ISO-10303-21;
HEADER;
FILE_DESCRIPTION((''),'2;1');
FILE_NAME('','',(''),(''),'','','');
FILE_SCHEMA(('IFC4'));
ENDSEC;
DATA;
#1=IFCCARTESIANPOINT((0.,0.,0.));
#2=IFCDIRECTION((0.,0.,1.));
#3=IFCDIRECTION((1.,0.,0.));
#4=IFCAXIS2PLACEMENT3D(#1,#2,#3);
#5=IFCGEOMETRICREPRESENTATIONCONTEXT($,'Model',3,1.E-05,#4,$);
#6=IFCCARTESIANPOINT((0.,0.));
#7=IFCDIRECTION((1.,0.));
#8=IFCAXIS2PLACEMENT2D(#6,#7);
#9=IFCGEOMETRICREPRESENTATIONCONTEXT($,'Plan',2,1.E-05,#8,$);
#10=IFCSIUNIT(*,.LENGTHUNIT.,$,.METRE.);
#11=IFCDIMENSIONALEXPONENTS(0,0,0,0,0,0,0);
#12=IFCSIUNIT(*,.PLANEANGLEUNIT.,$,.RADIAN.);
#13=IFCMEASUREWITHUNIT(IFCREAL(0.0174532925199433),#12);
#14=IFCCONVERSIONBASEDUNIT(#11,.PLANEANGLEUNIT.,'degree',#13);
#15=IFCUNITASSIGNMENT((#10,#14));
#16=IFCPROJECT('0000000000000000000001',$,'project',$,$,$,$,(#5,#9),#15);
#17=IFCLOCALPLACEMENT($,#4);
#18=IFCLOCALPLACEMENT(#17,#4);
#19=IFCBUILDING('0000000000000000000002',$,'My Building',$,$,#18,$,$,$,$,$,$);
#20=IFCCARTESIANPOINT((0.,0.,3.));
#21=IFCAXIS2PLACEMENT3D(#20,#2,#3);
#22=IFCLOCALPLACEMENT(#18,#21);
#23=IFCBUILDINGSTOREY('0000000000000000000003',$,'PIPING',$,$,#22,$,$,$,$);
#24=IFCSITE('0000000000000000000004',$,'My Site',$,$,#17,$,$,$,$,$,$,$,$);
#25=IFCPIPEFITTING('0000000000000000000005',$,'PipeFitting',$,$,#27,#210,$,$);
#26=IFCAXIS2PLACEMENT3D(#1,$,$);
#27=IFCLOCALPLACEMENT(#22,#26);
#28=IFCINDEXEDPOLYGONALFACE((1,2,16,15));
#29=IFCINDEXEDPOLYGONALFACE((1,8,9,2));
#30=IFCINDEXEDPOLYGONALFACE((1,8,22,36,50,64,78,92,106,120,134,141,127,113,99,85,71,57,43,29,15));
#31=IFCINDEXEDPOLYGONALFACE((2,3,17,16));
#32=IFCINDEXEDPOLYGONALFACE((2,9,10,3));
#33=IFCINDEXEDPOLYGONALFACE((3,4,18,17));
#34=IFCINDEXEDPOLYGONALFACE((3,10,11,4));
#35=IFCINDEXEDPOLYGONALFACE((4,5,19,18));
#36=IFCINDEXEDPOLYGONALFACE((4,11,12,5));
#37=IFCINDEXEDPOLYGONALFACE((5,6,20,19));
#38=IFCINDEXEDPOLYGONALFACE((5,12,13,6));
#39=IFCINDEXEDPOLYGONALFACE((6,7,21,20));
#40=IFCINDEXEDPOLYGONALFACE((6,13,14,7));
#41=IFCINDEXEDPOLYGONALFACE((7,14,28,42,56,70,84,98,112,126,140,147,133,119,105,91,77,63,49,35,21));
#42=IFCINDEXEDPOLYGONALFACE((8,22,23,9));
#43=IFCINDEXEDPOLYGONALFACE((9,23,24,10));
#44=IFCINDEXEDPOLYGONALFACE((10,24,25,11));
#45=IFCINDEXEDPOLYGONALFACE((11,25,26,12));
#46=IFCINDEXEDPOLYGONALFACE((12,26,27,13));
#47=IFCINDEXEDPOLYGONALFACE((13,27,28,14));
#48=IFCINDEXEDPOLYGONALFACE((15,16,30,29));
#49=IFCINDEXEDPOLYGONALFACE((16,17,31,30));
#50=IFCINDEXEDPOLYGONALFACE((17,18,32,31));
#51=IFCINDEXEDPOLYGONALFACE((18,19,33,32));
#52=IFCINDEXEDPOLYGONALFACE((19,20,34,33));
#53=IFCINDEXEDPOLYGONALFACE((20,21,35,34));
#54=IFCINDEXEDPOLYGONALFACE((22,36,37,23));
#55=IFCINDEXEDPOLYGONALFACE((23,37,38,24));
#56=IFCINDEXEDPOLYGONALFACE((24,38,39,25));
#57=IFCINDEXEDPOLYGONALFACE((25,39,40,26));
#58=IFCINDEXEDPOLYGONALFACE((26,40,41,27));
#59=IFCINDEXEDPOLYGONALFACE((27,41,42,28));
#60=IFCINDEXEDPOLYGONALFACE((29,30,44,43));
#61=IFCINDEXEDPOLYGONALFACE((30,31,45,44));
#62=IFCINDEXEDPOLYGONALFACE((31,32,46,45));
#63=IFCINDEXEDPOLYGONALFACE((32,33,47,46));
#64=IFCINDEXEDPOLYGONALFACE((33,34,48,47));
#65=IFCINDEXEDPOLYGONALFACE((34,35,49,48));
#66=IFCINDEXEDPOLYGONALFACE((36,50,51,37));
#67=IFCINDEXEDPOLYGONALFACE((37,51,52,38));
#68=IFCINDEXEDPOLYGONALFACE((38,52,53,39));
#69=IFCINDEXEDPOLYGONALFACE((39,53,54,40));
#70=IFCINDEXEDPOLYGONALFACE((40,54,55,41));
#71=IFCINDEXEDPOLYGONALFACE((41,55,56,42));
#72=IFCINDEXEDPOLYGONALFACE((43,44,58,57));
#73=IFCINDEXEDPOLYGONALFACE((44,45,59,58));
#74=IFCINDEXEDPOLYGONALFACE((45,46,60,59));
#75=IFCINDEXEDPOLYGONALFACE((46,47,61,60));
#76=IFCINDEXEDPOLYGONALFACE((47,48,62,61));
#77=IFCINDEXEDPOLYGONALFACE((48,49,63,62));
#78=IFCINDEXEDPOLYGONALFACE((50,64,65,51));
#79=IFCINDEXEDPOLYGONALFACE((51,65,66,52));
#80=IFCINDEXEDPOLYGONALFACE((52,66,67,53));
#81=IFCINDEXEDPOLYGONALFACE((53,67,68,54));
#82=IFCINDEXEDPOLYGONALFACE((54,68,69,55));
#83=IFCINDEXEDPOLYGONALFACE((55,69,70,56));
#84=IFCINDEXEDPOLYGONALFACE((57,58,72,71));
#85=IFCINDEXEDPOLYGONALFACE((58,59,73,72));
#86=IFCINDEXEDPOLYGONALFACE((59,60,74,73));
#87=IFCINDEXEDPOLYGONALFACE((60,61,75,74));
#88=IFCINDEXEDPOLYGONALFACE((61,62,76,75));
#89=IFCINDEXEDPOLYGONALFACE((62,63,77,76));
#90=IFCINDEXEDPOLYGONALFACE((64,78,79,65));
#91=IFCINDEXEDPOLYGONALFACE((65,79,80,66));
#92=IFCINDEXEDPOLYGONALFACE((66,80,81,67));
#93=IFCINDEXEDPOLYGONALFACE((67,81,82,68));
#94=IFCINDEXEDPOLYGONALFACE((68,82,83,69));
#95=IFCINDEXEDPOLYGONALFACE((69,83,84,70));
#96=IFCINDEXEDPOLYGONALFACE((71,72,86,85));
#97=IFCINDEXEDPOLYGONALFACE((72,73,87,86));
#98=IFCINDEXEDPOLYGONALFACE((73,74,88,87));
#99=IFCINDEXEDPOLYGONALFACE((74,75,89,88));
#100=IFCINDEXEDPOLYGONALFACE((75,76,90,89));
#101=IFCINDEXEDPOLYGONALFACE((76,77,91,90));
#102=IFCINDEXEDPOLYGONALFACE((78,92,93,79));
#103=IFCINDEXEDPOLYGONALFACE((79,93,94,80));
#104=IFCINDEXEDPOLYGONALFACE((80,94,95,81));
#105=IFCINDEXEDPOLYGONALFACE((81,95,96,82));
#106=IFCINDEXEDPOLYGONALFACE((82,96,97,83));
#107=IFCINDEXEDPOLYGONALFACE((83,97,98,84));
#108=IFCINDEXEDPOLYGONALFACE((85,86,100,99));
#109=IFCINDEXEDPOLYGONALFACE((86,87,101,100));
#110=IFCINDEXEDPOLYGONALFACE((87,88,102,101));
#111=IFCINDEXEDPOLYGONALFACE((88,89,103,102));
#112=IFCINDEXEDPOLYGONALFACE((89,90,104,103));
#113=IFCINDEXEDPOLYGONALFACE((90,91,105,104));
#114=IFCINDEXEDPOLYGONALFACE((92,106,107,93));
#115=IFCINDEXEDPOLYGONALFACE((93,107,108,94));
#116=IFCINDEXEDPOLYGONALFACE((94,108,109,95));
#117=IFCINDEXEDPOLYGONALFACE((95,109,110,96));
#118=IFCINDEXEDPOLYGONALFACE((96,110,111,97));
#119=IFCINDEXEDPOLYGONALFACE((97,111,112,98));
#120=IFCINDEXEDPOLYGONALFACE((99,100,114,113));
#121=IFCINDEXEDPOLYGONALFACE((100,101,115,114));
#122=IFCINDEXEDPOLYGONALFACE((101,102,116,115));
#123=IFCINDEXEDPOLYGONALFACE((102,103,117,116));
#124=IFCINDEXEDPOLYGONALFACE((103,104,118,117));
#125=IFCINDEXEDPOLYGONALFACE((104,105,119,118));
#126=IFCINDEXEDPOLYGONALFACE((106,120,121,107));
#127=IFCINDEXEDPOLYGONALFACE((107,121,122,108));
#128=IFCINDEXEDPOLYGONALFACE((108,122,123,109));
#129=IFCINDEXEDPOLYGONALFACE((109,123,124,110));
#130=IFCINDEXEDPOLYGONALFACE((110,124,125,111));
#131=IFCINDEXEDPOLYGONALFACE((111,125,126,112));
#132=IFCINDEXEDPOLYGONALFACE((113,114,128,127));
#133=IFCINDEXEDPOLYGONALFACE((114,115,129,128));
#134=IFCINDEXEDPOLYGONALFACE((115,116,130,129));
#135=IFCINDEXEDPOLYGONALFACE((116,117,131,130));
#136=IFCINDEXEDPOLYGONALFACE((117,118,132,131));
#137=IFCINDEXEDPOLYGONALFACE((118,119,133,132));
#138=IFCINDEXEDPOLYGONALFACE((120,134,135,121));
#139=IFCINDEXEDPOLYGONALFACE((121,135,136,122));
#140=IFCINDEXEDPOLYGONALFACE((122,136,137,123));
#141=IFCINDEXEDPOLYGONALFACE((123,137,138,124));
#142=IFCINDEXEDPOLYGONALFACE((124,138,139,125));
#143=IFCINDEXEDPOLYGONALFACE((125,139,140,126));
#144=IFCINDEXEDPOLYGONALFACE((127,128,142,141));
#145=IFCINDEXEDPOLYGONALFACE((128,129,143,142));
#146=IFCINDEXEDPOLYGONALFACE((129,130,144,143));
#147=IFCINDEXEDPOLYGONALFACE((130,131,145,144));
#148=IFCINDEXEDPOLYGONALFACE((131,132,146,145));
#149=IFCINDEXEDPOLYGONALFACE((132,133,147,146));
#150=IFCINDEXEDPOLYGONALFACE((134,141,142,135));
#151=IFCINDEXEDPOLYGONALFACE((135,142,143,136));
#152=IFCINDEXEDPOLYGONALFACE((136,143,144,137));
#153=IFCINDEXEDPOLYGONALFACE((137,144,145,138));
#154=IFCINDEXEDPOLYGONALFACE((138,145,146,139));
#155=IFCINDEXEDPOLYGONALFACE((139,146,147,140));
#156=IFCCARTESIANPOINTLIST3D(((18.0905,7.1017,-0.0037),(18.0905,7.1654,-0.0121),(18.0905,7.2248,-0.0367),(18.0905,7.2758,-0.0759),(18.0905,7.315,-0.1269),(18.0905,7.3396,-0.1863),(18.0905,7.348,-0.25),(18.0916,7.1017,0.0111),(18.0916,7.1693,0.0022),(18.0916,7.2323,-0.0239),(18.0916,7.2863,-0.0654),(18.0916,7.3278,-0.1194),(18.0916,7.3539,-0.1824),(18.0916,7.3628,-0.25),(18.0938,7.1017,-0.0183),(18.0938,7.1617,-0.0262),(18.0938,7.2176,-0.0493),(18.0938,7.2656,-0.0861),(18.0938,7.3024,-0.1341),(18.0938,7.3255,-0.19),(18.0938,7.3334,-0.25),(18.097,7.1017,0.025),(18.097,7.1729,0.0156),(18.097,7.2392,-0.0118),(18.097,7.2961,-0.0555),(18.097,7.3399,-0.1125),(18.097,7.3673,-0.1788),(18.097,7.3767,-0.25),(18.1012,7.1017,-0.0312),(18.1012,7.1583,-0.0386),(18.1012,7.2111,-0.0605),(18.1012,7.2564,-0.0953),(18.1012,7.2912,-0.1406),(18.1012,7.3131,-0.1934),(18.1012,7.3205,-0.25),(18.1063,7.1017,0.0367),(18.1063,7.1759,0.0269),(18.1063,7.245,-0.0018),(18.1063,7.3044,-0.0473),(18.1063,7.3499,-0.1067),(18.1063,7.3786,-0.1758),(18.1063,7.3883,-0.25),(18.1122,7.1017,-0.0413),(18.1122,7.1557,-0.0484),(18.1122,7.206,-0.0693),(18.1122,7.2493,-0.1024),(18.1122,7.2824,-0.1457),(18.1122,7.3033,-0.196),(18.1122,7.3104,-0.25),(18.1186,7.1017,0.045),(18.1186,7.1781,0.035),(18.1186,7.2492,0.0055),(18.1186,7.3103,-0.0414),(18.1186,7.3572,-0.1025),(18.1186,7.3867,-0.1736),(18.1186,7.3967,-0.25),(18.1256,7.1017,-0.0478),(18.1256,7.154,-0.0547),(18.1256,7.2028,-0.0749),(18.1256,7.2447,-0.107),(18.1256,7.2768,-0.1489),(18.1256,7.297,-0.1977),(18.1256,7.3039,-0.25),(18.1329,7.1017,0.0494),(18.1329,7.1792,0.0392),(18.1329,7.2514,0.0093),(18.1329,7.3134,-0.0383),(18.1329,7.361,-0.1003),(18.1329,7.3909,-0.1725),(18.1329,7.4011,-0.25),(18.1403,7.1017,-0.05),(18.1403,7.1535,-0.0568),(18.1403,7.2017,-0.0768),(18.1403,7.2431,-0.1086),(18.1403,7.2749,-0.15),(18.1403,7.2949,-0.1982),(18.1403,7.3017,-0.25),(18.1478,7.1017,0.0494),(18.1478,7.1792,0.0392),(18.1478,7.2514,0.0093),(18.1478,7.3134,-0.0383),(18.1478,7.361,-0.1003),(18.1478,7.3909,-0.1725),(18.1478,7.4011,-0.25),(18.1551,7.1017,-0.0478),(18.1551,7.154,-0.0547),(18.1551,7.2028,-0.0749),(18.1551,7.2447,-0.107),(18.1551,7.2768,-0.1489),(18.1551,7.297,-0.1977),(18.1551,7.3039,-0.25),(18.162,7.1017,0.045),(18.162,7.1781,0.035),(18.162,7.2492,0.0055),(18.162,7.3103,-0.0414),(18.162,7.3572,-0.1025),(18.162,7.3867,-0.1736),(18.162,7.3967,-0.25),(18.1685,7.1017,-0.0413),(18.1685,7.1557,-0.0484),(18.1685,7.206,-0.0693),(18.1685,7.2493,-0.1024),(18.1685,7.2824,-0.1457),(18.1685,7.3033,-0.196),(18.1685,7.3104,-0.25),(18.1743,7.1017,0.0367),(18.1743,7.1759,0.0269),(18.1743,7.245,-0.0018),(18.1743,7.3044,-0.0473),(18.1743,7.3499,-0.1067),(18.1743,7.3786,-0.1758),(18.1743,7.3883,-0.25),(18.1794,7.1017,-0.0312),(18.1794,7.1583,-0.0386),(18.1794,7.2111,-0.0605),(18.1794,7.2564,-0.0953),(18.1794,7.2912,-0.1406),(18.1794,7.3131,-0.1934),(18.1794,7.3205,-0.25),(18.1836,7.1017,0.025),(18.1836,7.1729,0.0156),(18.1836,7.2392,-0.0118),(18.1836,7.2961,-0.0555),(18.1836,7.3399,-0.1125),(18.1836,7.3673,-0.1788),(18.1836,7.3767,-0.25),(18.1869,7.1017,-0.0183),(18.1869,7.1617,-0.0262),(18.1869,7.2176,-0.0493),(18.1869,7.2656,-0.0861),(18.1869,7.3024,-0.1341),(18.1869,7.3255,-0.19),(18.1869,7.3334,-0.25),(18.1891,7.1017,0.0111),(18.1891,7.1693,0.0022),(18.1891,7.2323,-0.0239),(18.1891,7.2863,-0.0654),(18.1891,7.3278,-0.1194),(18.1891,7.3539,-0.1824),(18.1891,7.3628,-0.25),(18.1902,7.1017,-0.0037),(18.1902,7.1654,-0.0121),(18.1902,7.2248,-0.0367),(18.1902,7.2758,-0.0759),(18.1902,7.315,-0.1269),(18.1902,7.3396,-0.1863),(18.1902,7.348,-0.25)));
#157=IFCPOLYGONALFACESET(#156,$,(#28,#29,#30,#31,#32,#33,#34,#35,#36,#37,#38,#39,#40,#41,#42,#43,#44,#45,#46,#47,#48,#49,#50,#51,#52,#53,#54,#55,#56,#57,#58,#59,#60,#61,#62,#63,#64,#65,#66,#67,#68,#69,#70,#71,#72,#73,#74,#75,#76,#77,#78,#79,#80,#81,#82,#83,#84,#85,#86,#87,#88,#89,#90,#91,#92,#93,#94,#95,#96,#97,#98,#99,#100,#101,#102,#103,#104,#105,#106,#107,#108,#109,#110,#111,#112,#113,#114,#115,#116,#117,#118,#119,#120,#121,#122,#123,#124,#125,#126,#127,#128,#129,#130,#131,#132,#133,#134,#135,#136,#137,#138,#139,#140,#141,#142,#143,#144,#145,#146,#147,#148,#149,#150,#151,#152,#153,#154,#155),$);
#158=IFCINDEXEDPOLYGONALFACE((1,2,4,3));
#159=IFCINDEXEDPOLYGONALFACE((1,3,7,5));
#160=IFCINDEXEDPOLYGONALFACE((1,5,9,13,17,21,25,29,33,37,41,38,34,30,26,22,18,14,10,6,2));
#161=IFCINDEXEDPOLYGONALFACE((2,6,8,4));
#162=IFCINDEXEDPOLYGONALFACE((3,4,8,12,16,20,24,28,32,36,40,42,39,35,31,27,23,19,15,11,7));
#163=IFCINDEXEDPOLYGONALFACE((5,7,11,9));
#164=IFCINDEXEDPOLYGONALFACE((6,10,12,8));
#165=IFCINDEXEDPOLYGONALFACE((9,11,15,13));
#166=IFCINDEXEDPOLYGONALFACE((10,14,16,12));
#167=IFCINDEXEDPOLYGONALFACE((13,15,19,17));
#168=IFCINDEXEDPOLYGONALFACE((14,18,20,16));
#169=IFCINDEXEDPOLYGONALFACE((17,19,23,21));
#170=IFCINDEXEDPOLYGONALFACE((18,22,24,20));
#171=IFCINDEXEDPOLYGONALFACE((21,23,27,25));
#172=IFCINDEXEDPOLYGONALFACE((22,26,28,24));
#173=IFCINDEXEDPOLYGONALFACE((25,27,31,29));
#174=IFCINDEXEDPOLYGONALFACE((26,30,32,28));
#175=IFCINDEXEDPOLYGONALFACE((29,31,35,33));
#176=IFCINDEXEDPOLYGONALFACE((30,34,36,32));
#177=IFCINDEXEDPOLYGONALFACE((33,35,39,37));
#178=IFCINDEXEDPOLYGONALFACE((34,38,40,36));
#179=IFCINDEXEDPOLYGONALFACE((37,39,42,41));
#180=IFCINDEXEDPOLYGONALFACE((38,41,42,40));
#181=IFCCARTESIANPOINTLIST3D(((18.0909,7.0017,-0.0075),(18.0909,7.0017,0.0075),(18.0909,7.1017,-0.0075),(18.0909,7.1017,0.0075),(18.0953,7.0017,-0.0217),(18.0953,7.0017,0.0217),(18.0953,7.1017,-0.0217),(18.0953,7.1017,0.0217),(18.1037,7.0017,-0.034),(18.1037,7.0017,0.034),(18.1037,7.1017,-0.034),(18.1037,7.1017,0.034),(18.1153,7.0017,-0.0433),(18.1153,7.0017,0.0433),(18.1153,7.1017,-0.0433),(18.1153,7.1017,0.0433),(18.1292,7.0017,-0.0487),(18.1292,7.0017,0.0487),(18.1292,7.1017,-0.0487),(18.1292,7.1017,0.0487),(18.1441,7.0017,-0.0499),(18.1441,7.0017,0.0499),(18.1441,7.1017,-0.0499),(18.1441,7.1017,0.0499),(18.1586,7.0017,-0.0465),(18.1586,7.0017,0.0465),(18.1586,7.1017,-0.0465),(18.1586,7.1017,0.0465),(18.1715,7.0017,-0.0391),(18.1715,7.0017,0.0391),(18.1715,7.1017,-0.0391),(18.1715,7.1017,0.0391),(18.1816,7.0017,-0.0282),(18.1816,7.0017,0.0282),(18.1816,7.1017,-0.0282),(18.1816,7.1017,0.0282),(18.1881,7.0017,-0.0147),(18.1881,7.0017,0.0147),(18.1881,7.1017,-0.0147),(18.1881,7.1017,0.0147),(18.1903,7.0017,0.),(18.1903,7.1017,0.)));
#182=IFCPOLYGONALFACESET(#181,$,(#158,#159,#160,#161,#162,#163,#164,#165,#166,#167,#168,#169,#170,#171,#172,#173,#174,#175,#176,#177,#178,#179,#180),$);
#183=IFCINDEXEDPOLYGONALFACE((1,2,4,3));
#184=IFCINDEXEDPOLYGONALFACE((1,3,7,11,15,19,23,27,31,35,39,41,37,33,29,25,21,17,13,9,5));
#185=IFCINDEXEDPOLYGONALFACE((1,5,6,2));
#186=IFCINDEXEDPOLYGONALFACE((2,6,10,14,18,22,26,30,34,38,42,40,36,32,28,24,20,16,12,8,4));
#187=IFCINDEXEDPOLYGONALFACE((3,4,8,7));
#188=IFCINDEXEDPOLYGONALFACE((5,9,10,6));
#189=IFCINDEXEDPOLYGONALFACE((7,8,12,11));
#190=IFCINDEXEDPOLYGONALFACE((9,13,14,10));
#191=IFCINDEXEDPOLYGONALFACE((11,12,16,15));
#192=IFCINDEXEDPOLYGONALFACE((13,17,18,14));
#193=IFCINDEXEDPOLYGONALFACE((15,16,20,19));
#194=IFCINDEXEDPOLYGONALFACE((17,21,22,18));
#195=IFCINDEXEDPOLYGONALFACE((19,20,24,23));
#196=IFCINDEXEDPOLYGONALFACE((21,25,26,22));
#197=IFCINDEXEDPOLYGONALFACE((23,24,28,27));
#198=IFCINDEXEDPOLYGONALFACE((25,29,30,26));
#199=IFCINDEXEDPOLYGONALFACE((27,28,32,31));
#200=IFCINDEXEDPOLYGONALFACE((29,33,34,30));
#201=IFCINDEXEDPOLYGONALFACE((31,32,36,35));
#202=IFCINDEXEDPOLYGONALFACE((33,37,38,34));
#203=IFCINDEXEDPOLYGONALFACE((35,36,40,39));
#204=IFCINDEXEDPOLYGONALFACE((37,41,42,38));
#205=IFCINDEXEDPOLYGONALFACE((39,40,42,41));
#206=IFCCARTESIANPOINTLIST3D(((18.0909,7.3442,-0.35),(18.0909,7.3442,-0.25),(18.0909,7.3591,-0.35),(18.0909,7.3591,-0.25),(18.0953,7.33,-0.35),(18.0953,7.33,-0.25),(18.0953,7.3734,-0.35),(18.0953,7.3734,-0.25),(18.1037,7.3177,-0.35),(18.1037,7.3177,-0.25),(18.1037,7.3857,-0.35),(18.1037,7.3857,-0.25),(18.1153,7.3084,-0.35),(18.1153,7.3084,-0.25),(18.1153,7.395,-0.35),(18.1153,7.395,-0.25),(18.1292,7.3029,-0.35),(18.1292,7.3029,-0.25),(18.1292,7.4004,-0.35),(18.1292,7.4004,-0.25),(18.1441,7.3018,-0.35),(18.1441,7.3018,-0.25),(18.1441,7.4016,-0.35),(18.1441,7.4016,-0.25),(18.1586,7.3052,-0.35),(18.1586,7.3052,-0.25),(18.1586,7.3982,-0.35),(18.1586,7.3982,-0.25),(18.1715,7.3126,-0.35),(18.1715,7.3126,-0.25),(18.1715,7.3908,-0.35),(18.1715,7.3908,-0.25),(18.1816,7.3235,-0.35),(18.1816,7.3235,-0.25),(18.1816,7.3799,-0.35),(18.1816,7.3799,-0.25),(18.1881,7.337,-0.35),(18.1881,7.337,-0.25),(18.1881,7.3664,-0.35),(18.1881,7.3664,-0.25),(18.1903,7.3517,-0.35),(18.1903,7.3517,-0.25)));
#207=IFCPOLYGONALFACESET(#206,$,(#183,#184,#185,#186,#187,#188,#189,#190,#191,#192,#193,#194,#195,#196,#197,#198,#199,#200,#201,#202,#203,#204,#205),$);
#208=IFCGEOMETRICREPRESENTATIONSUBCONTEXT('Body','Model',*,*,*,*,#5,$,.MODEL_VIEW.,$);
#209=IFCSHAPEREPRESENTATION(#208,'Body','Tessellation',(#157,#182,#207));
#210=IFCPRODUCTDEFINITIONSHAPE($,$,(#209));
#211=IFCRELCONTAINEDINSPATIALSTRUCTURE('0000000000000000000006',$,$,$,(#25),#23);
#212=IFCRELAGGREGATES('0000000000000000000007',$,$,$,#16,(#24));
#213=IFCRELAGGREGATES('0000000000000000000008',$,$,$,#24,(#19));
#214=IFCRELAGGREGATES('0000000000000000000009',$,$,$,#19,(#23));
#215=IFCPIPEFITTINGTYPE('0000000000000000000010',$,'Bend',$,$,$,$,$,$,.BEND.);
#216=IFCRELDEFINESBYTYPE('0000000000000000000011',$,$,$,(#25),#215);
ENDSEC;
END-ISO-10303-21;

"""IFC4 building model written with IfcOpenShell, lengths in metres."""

from ifc_helpers import new_model, entity, si_unit, converted_unit, frame, origin_with_axes, origin_2d_with_axis, place, context, subcontext, project, spatial, circle, extrude, source, transform, mapped, type_object, type_shapes, element, save


model = new_model("IFC4")

# Units and contexts
model_context = context("Model", 3, precision=1e-05, world=origin_with_axes())
plan_context = context("Plan", 2, precision=1e-05, world=origin_2d_with_axis())
body_context = subcontext(model_context, "Body", "Model", "MODEL_VIEW")
ifc_project = project(units=[si_unit("LENGTHUNIT", "METRE"), converted_unit("PLANEANGLEUNIT", "degree", entity("IfcReal", 0.0174532925199433), si_unit("PLANEANGLEUNIT", "RADIAN"), dimensions=[0, 0, 0, 0, 0, 0, 0])], contexts=[model_context, plan_context])

# Site, building, storey
site_placement = place(None, origin_with_axes())
site = spatial("IfcSite", under=ifc_project, at=site_placement, Name="My Site")
building_placement = place(site_placement, origin_with_axes())
building = spatial("IfcBuilding", under=site, at=building_placement, Name="My Building")
storey_placement = place(building_placement, frame((0.0, 0.0, 3.0), z_axis=(0.0, 0.0, 1.0), x_axis=(1.0, 0.0, 0.0)))
storey = spatial("IfcBuildingStorey", under=building, at=storey_placement, Name="PIPING")

# Pipe fitting
pipe_fitting_type = type_object("IfcPipeFittingType", Name="Bend", PredefinedType="BEND")
shared_shape = source(origin_with_axes(), body_context, "Body", "SolidModel", [
    entity("IfcSweptDiskSolid", entity("IfcIndexedPolyCurve", entity("IfcCartesianPointList3D", [[0.0, 0.0, -0.1], [0.0, -0.0732, -0.2768], [0.0, -0.25, -0.35]]), [entity("IfcArcIndex", [1, 2, 3])]), 0.05),
    extrude(circle(Radius=0.05), origin_with_axes(), (0.0, 0.0, -1.0), 0.1),
    extrude(circle(Radius=0.05), frame((0.0, -0.25, -0.35), z_axis=(0.0, -1.0, 0.0), x_axis=(1.0, 0.0, 0.0)), (0.0, 0.0, 1.0), 0.1),
])
type_shapes(pipe_fitting_type, [shared_shape])
for number, where, z_axis, x_axis, name in (
    (1, (18.1403, 7.0017, 0.0), (0.0, -1.0, 0.0), (1.0, 0.0, 0.0), "PipeFitting"),
):
    element("IfcPipeFitting", number, at=place(storey_placement, frame(where, z_axis=z_axis, x_axis=x_axis)), inside=storey, type_object=pipe_fitting_type, Name=name, context=body_context, shape_type="MappedRepresentation", body=[
        mapped(shared_shape, transform((0.0, 0.0, 0.0), x_axis=(1.0, 0.0, 0.0), y_axis=(0.0, 1.0, 0.0), z_axis=(0.0, 0.0, 1.0), scale=1.0)),
    ])

save(model, "model.ifc")
